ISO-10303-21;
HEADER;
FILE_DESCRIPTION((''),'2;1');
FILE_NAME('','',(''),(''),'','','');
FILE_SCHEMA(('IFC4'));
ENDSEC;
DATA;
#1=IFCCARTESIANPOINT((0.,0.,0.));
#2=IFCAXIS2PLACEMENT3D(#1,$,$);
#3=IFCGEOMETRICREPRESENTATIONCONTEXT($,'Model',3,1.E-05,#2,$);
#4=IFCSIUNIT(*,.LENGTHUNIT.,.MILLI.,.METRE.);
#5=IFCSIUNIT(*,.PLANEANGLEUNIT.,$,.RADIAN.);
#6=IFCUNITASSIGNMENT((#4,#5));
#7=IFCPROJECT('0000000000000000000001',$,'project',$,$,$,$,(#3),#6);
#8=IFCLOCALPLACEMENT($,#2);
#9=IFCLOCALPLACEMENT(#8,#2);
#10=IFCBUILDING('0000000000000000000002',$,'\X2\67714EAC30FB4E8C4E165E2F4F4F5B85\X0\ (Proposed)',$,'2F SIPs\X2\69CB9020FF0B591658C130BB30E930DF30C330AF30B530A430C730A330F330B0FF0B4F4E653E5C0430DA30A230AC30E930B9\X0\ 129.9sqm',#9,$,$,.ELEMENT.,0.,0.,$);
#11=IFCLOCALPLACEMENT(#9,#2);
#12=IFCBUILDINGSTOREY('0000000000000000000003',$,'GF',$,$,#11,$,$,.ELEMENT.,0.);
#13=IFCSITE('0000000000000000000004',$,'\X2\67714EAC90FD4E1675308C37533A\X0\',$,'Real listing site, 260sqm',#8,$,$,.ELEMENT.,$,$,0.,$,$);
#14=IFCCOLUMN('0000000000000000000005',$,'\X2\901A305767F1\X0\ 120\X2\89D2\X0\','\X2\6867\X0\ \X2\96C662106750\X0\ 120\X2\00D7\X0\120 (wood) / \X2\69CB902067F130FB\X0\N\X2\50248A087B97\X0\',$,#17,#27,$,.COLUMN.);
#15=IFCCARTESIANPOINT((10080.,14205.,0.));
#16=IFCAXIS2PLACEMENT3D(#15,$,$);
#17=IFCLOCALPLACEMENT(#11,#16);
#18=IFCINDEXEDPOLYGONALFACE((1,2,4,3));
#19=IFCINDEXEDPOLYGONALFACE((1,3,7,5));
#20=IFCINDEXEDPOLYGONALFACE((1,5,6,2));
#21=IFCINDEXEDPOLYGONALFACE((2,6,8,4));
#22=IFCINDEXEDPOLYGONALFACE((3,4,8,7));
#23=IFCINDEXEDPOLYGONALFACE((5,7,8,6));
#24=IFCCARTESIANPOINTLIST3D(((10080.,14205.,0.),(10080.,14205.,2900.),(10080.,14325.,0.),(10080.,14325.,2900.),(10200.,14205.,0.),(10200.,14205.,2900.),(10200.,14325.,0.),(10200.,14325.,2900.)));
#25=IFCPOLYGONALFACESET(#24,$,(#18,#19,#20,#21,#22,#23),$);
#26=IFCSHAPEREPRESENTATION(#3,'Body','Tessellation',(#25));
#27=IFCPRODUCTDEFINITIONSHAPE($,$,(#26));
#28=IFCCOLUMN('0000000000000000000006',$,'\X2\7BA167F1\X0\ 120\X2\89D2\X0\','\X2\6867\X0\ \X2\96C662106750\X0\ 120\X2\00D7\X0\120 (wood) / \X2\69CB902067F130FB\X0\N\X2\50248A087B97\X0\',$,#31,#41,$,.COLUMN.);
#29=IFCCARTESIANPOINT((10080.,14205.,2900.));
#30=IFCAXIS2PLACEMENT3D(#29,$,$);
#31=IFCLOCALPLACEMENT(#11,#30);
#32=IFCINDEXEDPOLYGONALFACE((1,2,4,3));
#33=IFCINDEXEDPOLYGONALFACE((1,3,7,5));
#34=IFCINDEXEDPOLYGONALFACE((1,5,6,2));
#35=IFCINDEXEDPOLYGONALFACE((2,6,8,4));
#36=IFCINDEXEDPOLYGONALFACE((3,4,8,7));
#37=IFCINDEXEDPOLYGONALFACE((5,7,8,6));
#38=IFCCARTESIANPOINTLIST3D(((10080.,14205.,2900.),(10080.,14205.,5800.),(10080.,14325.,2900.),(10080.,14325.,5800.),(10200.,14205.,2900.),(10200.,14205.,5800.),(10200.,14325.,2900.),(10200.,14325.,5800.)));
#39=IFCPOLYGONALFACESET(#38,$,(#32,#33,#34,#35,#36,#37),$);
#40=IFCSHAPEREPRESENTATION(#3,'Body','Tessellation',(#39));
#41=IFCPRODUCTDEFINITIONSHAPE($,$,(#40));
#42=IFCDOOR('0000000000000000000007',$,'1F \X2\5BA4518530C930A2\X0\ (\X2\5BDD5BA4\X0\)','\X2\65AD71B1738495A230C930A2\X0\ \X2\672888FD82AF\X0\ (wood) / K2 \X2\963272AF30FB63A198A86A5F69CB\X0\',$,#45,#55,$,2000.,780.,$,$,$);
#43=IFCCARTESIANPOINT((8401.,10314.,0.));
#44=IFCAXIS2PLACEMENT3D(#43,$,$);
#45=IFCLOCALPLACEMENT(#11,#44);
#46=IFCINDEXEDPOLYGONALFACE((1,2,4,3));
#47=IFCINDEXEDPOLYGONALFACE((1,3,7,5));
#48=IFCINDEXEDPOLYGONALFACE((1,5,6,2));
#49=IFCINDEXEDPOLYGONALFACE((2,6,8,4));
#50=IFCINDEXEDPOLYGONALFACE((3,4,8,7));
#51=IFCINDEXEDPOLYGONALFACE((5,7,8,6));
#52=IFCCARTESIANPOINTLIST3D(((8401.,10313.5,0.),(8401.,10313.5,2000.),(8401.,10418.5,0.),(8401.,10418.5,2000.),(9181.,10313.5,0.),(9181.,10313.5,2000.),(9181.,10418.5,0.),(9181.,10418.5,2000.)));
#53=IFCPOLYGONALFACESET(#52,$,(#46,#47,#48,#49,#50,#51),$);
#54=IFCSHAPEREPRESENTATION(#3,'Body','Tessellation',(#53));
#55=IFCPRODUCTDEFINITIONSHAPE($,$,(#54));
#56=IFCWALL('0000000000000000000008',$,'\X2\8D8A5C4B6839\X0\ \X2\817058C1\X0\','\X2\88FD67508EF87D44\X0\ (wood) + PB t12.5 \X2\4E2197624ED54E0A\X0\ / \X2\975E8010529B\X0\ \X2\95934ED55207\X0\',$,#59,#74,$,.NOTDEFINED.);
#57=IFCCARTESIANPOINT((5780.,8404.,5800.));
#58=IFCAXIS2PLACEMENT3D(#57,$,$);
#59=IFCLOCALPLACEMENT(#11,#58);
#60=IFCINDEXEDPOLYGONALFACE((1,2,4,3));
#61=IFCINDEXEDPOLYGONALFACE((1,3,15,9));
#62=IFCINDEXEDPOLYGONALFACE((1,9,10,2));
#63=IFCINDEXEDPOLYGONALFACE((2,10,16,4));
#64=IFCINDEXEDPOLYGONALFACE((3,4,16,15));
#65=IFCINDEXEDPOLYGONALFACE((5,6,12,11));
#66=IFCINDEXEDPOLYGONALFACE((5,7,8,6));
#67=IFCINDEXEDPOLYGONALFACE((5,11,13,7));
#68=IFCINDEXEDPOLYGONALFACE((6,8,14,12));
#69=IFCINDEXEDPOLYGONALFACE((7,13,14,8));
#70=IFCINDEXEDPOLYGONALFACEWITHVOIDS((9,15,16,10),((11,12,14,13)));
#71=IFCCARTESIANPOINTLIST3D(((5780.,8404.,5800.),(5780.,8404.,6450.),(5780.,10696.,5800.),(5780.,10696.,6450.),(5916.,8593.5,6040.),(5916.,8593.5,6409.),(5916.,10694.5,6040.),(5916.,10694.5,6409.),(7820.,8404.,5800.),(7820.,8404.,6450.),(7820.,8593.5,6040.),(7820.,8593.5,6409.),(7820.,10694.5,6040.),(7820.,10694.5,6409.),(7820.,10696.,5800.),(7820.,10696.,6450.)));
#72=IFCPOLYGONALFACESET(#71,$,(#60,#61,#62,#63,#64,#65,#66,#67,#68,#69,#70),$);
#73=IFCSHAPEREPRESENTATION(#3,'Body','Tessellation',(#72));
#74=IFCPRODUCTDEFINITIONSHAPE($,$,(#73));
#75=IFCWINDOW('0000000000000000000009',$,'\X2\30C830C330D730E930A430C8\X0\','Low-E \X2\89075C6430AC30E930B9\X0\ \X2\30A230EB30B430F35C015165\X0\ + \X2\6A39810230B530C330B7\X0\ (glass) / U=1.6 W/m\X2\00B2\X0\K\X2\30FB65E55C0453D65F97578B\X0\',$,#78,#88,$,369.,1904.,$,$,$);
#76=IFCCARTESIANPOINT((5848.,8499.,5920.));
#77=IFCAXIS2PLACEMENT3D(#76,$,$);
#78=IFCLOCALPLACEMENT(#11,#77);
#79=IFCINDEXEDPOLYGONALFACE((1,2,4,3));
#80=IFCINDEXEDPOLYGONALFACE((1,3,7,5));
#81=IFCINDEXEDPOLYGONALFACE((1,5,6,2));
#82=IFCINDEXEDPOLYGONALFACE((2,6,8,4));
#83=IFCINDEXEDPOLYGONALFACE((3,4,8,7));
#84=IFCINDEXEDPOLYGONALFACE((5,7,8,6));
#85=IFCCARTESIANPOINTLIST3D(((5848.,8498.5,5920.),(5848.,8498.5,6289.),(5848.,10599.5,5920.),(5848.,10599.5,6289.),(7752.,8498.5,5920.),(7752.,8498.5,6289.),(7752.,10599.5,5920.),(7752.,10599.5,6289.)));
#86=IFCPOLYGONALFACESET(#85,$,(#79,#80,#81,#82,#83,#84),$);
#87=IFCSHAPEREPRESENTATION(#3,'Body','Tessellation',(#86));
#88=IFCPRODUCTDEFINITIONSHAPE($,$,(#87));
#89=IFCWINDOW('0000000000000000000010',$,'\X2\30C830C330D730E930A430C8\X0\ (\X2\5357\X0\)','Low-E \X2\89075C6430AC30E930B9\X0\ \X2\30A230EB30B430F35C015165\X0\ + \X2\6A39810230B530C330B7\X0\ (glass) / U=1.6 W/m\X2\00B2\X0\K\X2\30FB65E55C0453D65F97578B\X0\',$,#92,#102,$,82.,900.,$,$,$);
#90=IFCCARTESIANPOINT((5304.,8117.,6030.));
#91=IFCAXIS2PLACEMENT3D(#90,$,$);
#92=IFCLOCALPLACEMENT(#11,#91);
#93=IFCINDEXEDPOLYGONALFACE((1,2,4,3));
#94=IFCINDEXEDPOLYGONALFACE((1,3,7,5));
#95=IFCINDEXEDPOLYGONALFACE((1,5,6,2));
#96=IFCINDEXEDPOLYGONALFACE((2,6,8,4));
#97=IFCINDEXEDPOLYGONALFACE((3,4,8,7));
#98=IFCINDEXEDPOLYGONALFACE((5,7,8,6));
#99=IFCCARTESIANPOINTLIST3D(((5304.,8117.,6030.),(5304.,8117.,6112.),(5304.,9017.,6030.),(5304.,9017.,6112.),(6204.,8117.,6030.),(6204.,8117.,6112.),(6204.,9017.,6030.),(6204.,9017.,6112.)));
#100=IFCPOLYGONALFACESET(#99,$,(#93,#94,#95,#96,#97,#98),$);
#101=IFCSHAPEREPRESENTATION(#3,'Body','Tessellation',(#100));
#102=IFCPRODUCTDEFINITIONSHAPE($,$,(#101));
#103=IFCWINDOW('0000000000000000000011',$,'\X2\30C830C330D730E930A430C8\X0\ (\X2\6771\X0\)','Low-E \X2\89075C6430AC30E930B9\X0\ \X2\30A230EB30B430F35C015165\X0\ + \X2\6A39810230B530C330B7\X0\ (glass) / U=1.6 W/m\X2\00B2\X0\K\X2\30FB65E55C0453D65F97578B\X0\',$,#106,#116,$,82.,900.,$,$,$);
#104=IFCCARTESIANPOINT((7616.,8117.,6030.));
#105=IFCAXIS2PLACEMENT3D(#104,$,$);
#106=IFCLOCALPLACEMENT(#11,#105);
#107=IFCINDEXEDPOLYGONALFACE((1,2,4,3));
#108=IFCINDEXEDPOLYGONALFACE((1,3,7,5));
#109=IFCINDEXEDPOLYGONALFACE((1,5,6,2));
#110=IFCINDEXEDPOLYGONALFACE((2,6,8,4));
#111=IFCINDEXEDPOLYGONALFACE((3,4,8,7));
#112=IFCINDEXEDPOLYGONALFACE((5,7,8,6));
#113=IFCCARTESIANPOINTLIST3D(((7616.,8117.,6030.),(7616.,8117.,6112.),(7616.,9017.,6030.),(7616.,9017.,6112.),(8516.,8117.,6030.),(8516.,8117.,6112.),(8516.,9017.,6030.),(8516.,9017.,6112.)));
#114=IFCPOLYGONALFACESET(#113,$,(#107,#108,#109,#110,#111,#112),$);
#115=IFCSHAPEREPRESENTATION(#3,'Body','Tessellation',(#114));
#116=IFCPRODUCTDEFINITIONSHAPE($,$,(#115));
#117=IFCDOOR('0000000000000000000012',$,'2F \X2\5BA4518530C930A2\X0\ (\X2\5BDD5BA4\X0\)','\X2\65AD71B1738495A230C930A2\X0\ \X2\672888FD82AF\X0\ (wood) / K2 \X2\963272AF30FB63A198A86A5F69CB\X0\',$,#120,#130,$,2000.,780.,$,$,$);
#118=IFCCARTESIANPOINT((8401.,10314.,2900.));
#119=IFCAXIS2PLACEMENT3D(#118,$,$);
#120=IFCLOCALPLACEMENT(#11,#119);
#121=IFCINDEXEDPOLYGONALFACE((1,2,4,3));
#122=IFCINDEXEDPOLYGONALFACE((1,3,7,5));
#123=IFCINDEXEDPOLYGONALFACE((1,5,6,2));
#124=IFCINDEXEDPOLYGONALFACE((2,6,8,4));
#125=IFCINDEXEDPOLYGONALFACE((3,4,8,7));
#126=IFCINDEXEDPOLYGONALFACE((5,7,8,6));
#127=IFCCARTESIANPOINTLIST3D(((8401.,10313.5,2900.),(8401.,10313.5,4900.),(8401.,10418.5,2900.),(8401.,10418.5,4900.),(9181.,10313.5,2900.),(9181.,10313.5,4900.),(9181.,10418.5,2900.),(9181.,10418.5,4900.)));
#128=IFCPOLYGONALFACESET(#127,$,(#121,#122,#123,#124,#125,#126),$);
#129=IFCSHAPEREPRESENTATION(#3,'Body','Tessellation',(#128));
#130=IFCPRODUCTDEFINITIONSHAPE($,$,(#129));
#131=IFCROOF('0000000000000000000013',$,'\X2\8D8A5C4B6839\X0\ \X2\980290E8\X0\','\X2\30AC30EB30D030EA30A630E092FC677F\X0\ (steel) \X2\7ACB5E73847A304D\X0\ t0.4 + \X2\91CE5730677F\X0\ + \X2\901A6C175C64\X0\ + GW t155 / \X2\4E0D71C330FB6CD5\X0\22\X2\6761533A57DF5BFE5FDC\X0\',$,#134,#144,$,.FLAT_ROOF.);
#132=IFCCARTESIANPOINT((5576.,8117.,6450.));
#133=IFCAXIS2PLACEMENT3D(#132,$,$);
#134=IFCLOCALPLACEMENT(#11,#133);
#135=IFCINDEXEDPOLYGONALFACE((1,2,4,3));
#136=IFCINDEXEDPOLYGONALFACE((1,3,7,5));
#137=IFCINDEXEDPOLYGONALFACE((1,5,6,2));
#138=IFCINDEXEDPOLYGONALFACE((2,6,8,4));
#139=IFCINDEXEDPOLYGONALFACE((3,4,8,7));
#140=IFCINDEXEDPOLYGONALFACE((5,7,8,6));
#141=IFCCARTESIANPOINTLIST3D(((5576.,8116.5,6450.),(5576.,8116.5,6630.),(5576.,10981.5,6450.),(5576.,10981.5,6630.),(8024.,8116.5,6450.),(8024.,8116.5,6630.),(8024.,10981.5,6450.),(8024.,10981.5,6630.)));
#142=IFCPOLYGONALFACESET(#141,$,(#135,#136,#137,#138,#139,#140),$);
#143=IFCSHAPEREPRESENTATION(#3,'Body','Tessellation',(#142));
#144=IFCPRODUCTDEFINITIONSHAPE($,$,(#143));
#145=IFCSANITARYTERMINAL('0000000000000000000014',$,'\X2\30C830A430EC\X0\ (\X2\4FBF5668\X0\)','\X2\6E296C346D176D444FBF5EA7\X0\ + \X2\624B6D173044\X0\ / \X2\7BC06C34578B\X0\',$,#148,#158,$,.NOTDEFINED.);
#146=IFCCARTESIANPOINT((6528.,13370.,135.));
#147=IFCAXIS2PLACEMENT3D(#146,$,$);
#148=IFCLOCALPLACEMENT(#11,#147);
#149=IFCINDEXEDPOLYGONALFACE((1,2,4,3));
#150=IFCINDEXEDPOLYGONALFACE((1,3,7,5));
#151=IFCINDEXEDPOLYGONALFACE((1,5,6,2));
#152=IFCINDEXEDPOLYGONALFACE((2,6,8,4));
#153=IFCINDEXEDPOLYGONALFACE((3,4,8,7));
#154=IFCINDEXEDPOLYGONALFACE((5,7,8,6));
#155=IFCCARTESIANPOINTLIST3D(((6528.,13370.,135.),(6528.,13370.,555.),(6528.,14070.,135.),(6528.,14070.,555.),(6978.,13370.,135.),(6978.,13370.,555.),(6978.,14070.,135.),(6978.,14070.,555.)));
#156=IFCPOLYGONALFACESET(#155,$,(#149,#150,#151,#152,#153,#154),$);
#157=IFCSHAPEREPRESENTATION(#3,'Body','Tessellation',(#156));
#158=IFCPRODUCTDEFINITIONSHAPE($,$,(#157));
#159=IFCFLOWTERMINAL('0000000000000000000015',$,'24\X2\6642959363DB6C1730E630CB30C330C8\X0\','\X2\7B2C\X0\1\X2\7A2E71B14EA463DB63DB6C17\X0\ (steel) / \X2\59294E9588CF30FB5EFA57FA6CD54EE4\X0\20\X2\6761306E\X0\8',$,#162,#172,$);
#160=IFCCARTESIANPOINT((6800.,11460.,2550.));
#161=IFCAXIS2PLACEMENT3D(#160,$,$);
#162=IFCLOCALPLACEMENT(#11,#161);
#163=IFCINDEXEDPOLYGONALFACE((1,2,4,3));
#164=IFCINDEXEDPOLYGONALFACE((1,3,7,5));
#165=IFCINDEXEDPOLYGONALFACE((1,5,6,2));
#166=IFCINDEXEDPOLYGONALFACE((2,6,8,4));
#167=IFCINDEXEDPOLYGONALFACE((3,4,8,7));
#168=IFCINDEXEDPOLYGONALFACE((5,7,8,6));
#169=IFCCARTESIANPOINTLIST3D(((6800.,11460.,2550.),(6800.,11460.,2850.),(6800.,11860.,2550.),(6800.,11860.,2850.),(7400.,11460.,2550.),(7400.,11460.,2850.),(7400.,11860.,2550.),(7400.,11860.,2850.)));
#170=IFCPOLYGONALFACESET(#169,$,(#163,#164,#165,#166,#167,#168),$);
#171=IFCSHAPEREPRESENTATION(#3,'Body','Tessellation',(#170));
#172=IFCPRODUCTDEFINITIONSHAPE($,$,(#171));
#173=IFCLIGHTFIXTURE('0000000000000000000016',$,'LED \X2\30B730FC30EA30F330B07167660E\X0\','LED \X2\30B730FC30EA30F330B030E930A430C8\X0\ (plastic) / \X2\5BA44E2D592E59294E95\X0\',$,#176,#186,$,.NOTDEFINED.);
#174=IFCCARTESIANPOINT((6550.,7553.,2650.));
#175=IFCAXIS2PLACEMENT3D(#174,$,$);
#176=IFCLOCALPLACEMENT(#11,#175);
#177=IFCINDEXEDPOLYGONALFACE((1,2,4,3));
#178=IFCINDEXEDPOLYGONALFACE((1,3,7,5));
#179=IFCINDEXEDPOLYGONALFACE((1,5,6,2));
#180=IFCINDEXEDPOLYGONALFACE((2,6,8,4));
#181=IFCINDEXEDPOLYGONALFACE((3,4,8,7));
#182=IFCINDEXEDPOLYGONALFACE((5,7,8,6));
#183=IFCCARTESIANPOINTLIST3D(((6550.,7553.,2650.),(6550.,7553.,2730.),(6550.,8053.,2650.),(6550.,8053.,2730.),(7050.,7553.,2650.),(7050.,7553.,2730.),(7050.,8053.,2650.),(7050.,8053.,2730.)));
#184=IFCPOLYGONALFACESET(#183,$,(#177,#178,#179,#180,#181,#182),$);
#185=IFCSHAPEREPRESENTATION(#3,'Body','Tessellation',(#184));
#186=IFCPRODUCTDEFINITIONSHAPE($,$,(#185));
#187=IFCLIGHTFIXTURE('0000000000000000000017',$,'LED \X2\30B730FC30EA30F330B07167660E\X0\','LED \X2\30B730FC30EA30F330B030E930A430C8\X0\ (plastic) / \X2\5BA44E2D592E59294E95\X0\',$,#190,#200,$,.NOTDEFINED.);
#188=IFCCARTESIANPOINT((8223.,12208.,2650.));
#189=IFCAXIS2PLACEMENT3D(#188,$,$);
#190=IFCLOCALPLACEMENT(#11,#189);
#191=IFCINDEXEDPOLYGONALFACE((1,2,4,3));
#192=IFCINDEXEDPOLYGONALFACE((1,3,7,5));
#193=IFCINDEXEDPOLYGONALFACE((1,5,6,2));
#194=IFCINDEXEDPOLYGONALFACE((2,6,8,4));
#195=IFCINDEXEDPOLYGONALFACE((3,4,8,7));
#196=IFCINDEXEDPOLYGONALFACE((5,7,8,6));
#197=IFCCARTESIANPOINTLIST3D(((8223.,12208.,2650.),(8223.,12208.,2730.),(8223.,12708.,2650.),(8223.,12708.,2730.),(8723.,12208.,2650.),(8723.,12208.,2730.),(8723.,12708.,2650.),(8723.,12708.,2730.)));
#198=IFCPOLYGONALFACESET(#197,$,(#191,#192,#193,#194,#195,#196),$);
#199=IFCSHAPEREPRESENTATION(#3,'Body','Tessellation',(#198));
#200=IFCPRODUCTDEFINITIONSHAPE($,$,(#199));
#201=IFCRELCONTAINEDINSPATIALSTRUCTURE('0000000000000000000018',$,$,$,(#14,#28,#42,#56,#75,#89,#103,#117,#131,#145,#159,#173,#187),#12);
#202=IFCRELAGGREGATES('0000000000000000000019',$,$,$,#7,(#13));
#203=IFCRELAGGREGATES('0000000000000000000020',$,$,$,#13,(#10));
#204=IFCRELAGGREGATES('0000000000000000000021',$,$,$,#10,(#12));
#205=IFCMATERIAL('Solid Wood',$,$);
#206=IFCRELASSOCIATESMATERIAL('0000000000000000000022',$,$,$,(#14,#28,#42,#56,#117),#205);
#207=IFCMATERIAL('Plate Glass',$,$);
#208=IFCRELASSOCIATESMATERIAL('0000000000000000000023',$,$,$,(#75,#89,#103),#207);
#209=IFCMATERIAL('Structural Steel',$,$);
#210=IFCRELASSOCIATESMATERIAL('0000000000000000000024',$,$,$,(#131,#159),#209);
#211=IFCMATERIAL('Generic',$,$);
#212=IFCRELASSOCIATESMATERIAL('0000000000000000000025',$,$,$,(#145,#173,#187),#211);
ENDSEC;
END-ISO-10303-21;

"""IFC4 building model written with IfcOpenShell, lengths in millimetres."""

from ifc_helpers import new_model, si_unit, frame, frame_2d, origin, place, context, project, spatial, rectangle, extrude, material, element, fill, save


model = new_model("IFC4")

# Units and contexts
model_context = context("Model", 3, precision=1e-05, world=origin())
ifc_project = project(units=[si_unit("LENGTHUNIT", "METRE", prefix="MILLI"), si_unit("PLANEANGLEUNIT", "RADIAN")], contexts=[model_context])

# Site, building, storey
site_placement = place(None, origin())
site = spatial("IfcSite", under=ifc_project, at=site_placement, Name="東京都世田谷区", ObjectType="Real listing site, 260sqm", CompositionType="ELEMENT", RefElevation=0.0)
building_placement = place(site_placement, origin())
building = spatial("IfcBuilding", under=site, at=building_placement, Name="東京・二世帯住宅 (Proposed)", ObjectType="2F SIPs構造＋外壁セラミックサイディング＋低放射ペアガラス 129.9sqm", CompositionType="ELEMENT", ElevationOfRefHeight=0.0, ElevationOfTerrain=0.0)
storey_placement = place(building_placement, origin())
storey = spatial("IfcBuildingStorey", under=building, at=storey_placement, Name="GF", CompositionType="ELEMENT", Elevation=0.0)

# Columns
ifc_material_1 = material(Name="Solid Wood")
column_1_placement = place(storey_placement, frame((10080.0, 14205.0, 0.0)))
element("IfcColumn", 1, at=column_1_placement, inside=storey, material=ifc_material_1, Name="通し柱 120角", Description="桧 集成材 120×120 (wood) / 構造柱・N値計算", PredefinedType="COLUMN", context=model_context, shape_type="SweptSolid", body=[
    extrude(rectangle(XDim=120.0, YDim=120.0, at=frame_2d((60.0, 60.0))), frame((10080.0, 14205.0, 0.0)), (0.0, 0.0, 1.0), 2900.0),
])
column_2_placement = place(storey_placement, frame((10080.0, 14205.0, 2900.0)))
element("IfcColumn", 2, at=column_2_placement, inside=storey, material=ifc_material_1, Name="管柱 120角", Description="桧 集成材 120×120 (wood) / 構造柱・N値計算", PredefinedType="COLUMN", context=model_context, shape_type="SweptSolid", body=[
    extrude(rectangle(XDim=120.0, YDim=120.0, at=frame_2d((60.0, 60.0))), frame((10080.0, 14205.0, 2900.0)), (0.0, 0.0, 1.0), 2900.0),
])

# Door
door_1_placement = place(storey_placement, frame((8401.0, 10314.0, 0.0)))
element("IfcDoor", 3, at=door_1_placement, inside=storey, material=ifc_material_1, Name="1F 室内ドア (寝室)", Description="断熱玄関ドア 木製芯 (wood) / K2 防犯・採風機構", OverallHeight=2000.0, OverallWidth=780.0, context=model_context, shape_type="SweptSolid", body=[
    extrude(rectangle(XDim=780.0, YDim=105.0, at=frame_2d((390.0, 52.0))), frame((8401.0, 10314.0, 0.0)), (0.0, 0.0, 1.0), 2000.0),
])

# Wall, openings, windows
wall_1_placement = place(storey_placement, frame((5780.0, 8404.0, 5800.0)))
wall_1 = element("IfcWall", 4, at=wall_1_placement, inside=storey, material=ifc_material_1, Name="越屋根 腰壁", Description="製材軸組 (wood) + PB t12.5 両面仕上 / 非耐力 間仕切", PredefinedType="NOTDEFINED", context=model_context, shape_type="SweptSolid", body=[
    extrude(rectangle(XDim=2040.0, YDim=2292.0, at=frame_2d((1020.0, 1146.0))), frame((5780.0, 8404.0, 5800.0)), (0.0, 0.0, 1.0), 650.0),
])
opening_1_placement = place(storey_placement, frame((5848.0, 8499.0, 5920.0)))
opening_1 = element("IfcOpeningElement", 5, at=opening_1_placement, cuts=wall_1, PredefinedType="NOTDEFINED", context=model_context, shape_type="SweptSolid", body=[
    extrude(rectangle(XDim=1904.0, YDim=2101.0, at=frame_2d((952.0, 1050.0))), frame((5848.0, 8499.0, 5920.0)), (0.0, 0.0, 1.0), 369.0),
])
opening_2_placement = place(storey_placement, frame((5304.0, 8117.0, 6030.0)))
opening_2 = element("IfcOpeningElement", 6, at=opening_2_placement, cuts=wall_1, PredefinedType="NOTDEFINED", context=model_context, shape_type="SweptSolid", body=[
    extrude(rectangle(XDim=900.0, YDim=900.0, at=frame_2d((450.0, 450.0))), frame((5304.0, 8117.0, 6030.0)), (0.0, 0.0, 1.0), 82.0),
])
opening_3_placement = place(storey_placement, frame((7616.0, 8117.0, 6030.0)))
opening_3 = element("IfcOpeningElement", 7, at=opening_3_placement, cuts=wall_1, PredefinedType="NOTDEFINED", context=model_context, shape_type="SweptSolid", body=[
    extrude(rectangle(XDim=900.0, YDim=900.0, at=frame_2d((450.0, 450.0))), frame((7616.0, 8117.0, 6030.0)), (0.0, 0.0, 1.0), 82.0),
])
ifc_material_2 = material(Name="Plate Glass")
window_1_placement = place(storey_placement, frame((5848.0, 8499.0, 5920.0)))
window_1 = element("IfcWindow", 8, at=window_1_placement, inside=storey, material=ifc_material_2, Name="トップライト", Description="Low-E 複層ガラス アルゴン封入 + 樹脂サッシ (glass) / U=1.6 W/m²K・日射取得型", OverallHeight=369.0, OverallWidth=1904.0, context=model_context, shape_type="SweptSolid", body=[
    extrude(rectangle(XDim=1904.0, YDim=2101.0, at=frame_2d((952.0, 1050.0))), frame((5848.0, 8499.0, 5920.0)), (0.0, 0.0, 1.0), 369.0),
])
fill(opening_1, window_1)
window_2_placement = place(storey_placement, frame((5304.0, 8117.0, 6030.0)))
window_2 = element("IfcWindow", 9, at=window_2_placement, inside=storey, material=ifc_material_2, Name="トップライト (南)", Description="Low-E 複層ガラス アルゴン封入 + 樹脂サッシ (glass) / U=1.6 W/m²K・日射取得型", OverallHeight=82.0, OverallWidth=900.0, context=model_context, shape_type="SweptSolid", body=[
    extrude(rectangle(XDim=900.0, YDim=900.0, at=frame_2d((450.0, 450.0))), frame((5304.0, 8117.0, 6030.0)), (0.0, 0.0, 1.0), 82.0),
])
fill(opening_2, window_2)
window_3_placement = place(storey_placement, frame((7616.0, 8117.0, 6030.0)))
window_3 = element("IfcWindow", 10, at=window_3_placement, inside=storey, material=ifc_material_2, Name="トップライト (東)", Description="Low-E 複層ガラス アルゴン封入 + 樹脂サッシ (glass) / U=1.6 W/m²K・日射取得型", OverallHeight=82.0, OverallWidth=900.0, context=model_context, shape_type="SweptSolid", body=[
    extrude(rectangle(XDim=900.0, YDim=900.0, at=frame_2d((450.0, 450.0))), frame((7616.0, 8117.0, 6030.0)), (0.0, 0.0, 1.0), 82.0),
])
fill(opening_3, window_3)

# Door
door_2_placement = place(storey_placement, frame((8401.0, 10314.0, 2900.0)))
element("IfcDoor", 11, at=door_2_placement, inside=storey, material=ifc_material_1, Name="2F 室内ドア (寝室)", Description="断熱玄関ドア 木製芯 (wood) / K2 防犯・採風機構", OverallHeight=2000.0, OverallWidth=780.0, context=model_context, shape_type="SweptSolid", body=[
    extrude(rectangle(XDim=780.0, YDim=105.0, at=frame_2d((390.0, 52.0))), frame((8401.0, 10314.0, 2900.0)), (0.0, 0.0, 1.0), 2000.0),
])

# Roof
ifc_material_3 = material(Name="Structural Steel")
roof_placement = place(storey_placement, frame((5576.0, 8117.0, 6450.0)))
element("IfcRoof", 12, at=roof_placement, inside=storey, material=ifc_material_3, Name="越屋根 頂部", Description="ガルバリウム鋼板 (steel) 立平葺き t0.4 + 野地板 + 通気層 + GW t155 / 不燃・法22条区域対応", PredefinedType="FLAT_ROOF", context=model_context, shape_type="SweptSolid", body=[
    extrude(rectangle(XDim=2448.0, YDim=2865.0, at=frame_2d((1224.0, 1432.0))), frame((5576.0, 8117.0, 6450.0)), (0.0, 0.0, 1.0), 180.0),
])

# Sanitary terminal
ifc_material_4 = material(Name="Generic")
sanitary_terminal_placement = place(storey_placement, frame((6528.0, 13370.0, 135.0)))
element("IfcSanitaryTerminal", 13, at=sanitary_terminal_placement, inside=storey, material=ifc_material_4, Name="トイレ (便器)", Description="温水洗浄便座 + 手洗い / 節水型", PredefinedType="NOTDEFINED", context=model_context, shape_type="SweptSolid", body=[
    extrude(rectangle(XDim=450.0, YDim=700.0, at=frame_2d((225.0, 350.0))), frame((6528.0, 13370.0, 135.0)), (0.0, 0.0, 1.0), 420.0),
])

# Flow terminal
flow_terminal_placement = place(storey_placement, frame((6800.0, 11460.0, 2550.0)))
element("IfcFlowTerminal", 14, at=flow_terminal_placement, inside=storey, material=ifc_material_3, Name="24時間換気ユニット", Description="第1種熱交換換気 (steel) / 天井裏・建基法令20条の8", context=model_context, shape_type="SweptSolid", body=[
    extrude(rectangle(XDim=600.0, YDim=400.0, at=frame_2d((300.0, 200.0))), frame((6800.0, 11460.0, 2550.0)), (0.0, 0.0, 1.0), 300.0),
])

# Light fixtures
light_fixture_1_placement = place(storey_placement, frame((6550.0, 7553.0, 2650.0)))
element("IfcLightFixture", 15, at=light_fixture_1_placement, inside=storey, material=ifc_material_4, Name="LED シーリング照明", Description="LED シーリングライト (plastic) / 室中央天井", PredefinedType="NOTDEFINED", context=model_context, shape_type="SweptSolid", body=[
    extrude(rectangle(XDim=500.0, YDim=500.0, at=frame_2d((250.0, 250.0))), frame((6550.0, 7553.0, 2650.0)), (0.0, 0.0, 1.0), 80.0),
])
light_fixture_2_placement = place(storey_placement, frame((8223.0, 12208.0, 2650.0)))
element("IfcLightFixture", 16, at=light_fixture_2_placement, inside=storey, material=ifc_material_4, Name="LED シーリング照明", Description="LED シーリングライト (plastic) / 室中央天井", PredefinedType="NOTDEFINED", context=model_context, shape_type="SweptSolid", body=[
    extrude(rectangle(XDim=500.0, YDim=500.0, at=frame_2d((250.0, 250.0))), frame((8223.0, 12208.0, 2650.0)), (0.0, 0.0, 1.0), 80.0),
])

save(model, "model.ifc")
